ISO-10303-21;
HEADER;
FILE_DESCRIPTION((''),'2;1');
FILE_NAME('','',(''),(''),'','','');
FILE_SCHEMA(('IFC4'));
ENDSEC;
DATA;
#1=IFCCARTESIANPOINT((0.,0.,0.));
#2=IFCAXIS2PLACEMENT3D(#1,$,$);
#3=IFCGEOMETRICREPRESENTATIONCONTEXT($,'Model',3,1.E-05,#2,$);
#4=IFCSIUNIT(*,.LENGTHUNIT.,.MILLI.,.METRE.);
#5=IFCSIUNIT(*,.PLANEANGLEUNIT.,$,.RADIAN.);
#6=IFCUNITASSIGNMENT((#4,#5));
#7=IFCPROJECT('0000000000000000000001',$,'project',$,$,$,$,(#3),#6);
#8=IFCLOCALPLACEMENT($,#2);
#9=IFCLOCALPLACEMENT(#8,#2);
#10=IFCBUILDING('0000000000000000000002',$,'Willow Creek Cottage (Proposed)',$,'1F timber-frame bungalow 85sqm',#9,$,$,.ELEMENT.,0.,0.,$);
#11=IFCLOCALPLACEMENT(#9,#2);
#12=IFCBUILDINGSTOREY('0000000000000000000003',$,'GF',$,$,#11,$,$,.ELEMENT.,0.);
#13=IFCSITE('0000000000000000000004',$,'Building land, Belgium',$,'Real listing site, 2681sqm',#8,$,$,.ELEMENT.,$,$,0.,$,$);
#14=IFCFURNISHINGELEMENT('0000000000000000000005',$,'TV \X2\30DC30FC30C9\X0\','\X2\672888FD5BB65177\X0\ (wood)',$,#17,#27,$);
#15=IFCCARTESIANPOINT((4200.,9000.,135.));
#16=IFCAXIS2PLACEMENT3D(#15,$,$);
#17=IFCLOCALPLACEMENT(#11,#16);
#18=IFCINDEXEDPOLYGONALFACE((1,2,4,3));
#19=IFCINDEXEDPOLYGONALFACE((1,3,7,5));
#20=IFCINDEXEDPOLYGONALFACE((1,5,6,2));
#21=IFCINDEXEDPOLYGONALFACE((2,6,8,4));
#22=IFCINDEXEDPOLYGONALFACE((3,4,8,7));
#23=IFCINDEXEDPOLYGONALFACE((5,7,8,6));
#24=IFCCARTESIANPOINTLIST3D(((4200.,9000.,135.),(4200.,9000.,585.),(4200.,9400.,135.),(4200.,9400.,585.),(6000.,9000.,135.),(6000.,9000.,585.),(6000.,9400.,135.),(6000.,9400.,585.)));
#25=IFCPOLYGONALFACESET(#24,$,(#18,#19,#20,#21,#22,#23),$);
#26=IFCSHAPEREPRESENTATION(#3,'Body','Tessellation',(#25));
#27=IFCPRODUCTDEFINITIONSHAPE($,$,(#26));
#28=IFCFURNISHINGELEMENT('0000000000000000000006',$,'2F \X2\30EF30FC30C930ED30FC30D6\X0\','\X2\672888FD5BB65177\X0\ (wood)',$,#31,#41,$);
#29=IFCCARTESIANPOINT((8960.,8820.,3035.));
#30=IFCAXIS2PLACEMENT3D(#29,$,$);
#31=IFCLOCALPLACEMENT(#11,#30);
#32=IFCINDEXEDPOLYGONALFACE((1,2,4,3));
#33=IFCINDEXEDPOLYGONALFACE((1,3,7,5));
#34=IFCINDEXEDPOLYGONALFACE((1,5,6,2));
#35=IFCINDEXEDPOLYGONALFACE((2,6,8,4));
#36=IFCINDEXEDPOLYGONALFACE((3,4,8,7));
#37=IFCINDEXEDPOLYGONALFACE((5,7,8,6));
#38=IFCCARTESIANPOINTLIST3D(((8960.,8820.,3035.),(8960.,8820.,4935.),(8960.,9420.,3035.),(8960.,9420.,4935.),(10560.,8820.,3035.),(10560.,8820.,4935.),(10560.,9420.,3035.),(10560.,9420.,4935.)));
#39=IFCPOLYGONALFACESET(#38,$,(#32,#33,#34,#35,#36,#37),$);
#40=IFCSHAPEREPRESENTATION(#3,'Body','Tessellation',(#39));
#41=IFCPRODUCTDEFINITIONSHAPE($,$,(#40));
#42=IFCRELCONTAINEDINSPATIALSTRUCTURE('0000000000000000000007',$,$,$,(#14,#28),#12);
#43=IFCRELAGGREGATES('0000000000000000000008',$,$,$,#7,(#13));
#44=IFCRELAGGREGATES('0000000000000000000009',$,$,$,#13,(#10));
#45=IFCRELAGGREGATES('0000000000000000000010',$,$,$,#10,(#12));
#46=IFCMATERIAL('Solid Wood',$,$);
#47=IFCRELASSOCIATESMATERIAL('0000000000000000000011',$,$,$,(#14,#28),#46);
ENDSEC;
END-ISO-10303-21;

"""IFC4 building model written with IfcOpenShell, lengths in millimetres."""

from ifc_helpers import new_model, si_unit, frame, frame_2d, origin, place, context, project, spatial, rectangle, extrude, material, element, save


model = new_model("IFC4")

# Units and contexts
model_context = context("Model", 3, precision=1e-05, world=origin())
ifc_project = project(units=[si_unit("LENGTHUNIT", "METRE", prefix="MILLI"), si_unit("PLANEANGLEUNIT", "RADIAN")], contexts=[model_context])

# Site, building, storey
site_placement = place(None, origin())
site = spatial("IfcSite", under=ifc_project, at=site_placement, Name="Building land, Belgium", ObjectType="Real listing site, 2681sqm", CompositionType="ELEMENT", RefElevation=0.0)
building_placement = place(site_placement, origin())
building = spatial("IfcBuilding", under=site, at=building_placement, Name="Willow Creek Cottage (Proposed)", ObjectType="1F timber-frame bungalow 85sqm", CompositionType="ELEMENT", ElevationOfRefHeight=0.0, ElevationOfTerrain=0.0)
storey_placement = place(building_placement, origin())
storey = spatial("IfcBuildingStorey", under=building, at=storey_placement, Name="GF", CompositionType="ELEMENT", Elevation=0.0)

# Shared definitions
ifc_material_1 = material(Name="Solid Wood")

# Furnishing elements
furnishing_1_placement = place(storey_placement, frame((4200.0, 9000.0, 135.0)))
element("IfcFurnishingElement", 1, at=furnishing_1_placement, inside=storey, material=ifc_material_1, Name="TV ボード", Description="木製家具 (wood)", context=model_context, shape_type="SweptSolid", body=[
    extrude(rectangle(XDim=1800.0, YDim=400.0, at=frame_2d((900.0, 200.0))), frame((4200.0, 9000.0, 135.0)), (0.0, 0.0, 1.0), 450.0),
])
furnishing_2_placement = place(storey_placement, frame((8960.0, 8820.0, 3035.0)))
element("IfcFurnishingElement", 2, at=furnishing_2_placement, inside=storey, material=ifc_material_1, Name="2F ワードローブ", Description="木製家具 (wood)", context=model_context, shape_type="SweptSolid", body=[
    extrude(rectangle(XDim=1600.0, YDim=600.0, at=frame_2d((800.0, 300.0))), frame((8960.0, 8820.0, 3035.0)), (0.0, 0.0, 1.0), 1900.0),
])

save(model, "model.ifc")
